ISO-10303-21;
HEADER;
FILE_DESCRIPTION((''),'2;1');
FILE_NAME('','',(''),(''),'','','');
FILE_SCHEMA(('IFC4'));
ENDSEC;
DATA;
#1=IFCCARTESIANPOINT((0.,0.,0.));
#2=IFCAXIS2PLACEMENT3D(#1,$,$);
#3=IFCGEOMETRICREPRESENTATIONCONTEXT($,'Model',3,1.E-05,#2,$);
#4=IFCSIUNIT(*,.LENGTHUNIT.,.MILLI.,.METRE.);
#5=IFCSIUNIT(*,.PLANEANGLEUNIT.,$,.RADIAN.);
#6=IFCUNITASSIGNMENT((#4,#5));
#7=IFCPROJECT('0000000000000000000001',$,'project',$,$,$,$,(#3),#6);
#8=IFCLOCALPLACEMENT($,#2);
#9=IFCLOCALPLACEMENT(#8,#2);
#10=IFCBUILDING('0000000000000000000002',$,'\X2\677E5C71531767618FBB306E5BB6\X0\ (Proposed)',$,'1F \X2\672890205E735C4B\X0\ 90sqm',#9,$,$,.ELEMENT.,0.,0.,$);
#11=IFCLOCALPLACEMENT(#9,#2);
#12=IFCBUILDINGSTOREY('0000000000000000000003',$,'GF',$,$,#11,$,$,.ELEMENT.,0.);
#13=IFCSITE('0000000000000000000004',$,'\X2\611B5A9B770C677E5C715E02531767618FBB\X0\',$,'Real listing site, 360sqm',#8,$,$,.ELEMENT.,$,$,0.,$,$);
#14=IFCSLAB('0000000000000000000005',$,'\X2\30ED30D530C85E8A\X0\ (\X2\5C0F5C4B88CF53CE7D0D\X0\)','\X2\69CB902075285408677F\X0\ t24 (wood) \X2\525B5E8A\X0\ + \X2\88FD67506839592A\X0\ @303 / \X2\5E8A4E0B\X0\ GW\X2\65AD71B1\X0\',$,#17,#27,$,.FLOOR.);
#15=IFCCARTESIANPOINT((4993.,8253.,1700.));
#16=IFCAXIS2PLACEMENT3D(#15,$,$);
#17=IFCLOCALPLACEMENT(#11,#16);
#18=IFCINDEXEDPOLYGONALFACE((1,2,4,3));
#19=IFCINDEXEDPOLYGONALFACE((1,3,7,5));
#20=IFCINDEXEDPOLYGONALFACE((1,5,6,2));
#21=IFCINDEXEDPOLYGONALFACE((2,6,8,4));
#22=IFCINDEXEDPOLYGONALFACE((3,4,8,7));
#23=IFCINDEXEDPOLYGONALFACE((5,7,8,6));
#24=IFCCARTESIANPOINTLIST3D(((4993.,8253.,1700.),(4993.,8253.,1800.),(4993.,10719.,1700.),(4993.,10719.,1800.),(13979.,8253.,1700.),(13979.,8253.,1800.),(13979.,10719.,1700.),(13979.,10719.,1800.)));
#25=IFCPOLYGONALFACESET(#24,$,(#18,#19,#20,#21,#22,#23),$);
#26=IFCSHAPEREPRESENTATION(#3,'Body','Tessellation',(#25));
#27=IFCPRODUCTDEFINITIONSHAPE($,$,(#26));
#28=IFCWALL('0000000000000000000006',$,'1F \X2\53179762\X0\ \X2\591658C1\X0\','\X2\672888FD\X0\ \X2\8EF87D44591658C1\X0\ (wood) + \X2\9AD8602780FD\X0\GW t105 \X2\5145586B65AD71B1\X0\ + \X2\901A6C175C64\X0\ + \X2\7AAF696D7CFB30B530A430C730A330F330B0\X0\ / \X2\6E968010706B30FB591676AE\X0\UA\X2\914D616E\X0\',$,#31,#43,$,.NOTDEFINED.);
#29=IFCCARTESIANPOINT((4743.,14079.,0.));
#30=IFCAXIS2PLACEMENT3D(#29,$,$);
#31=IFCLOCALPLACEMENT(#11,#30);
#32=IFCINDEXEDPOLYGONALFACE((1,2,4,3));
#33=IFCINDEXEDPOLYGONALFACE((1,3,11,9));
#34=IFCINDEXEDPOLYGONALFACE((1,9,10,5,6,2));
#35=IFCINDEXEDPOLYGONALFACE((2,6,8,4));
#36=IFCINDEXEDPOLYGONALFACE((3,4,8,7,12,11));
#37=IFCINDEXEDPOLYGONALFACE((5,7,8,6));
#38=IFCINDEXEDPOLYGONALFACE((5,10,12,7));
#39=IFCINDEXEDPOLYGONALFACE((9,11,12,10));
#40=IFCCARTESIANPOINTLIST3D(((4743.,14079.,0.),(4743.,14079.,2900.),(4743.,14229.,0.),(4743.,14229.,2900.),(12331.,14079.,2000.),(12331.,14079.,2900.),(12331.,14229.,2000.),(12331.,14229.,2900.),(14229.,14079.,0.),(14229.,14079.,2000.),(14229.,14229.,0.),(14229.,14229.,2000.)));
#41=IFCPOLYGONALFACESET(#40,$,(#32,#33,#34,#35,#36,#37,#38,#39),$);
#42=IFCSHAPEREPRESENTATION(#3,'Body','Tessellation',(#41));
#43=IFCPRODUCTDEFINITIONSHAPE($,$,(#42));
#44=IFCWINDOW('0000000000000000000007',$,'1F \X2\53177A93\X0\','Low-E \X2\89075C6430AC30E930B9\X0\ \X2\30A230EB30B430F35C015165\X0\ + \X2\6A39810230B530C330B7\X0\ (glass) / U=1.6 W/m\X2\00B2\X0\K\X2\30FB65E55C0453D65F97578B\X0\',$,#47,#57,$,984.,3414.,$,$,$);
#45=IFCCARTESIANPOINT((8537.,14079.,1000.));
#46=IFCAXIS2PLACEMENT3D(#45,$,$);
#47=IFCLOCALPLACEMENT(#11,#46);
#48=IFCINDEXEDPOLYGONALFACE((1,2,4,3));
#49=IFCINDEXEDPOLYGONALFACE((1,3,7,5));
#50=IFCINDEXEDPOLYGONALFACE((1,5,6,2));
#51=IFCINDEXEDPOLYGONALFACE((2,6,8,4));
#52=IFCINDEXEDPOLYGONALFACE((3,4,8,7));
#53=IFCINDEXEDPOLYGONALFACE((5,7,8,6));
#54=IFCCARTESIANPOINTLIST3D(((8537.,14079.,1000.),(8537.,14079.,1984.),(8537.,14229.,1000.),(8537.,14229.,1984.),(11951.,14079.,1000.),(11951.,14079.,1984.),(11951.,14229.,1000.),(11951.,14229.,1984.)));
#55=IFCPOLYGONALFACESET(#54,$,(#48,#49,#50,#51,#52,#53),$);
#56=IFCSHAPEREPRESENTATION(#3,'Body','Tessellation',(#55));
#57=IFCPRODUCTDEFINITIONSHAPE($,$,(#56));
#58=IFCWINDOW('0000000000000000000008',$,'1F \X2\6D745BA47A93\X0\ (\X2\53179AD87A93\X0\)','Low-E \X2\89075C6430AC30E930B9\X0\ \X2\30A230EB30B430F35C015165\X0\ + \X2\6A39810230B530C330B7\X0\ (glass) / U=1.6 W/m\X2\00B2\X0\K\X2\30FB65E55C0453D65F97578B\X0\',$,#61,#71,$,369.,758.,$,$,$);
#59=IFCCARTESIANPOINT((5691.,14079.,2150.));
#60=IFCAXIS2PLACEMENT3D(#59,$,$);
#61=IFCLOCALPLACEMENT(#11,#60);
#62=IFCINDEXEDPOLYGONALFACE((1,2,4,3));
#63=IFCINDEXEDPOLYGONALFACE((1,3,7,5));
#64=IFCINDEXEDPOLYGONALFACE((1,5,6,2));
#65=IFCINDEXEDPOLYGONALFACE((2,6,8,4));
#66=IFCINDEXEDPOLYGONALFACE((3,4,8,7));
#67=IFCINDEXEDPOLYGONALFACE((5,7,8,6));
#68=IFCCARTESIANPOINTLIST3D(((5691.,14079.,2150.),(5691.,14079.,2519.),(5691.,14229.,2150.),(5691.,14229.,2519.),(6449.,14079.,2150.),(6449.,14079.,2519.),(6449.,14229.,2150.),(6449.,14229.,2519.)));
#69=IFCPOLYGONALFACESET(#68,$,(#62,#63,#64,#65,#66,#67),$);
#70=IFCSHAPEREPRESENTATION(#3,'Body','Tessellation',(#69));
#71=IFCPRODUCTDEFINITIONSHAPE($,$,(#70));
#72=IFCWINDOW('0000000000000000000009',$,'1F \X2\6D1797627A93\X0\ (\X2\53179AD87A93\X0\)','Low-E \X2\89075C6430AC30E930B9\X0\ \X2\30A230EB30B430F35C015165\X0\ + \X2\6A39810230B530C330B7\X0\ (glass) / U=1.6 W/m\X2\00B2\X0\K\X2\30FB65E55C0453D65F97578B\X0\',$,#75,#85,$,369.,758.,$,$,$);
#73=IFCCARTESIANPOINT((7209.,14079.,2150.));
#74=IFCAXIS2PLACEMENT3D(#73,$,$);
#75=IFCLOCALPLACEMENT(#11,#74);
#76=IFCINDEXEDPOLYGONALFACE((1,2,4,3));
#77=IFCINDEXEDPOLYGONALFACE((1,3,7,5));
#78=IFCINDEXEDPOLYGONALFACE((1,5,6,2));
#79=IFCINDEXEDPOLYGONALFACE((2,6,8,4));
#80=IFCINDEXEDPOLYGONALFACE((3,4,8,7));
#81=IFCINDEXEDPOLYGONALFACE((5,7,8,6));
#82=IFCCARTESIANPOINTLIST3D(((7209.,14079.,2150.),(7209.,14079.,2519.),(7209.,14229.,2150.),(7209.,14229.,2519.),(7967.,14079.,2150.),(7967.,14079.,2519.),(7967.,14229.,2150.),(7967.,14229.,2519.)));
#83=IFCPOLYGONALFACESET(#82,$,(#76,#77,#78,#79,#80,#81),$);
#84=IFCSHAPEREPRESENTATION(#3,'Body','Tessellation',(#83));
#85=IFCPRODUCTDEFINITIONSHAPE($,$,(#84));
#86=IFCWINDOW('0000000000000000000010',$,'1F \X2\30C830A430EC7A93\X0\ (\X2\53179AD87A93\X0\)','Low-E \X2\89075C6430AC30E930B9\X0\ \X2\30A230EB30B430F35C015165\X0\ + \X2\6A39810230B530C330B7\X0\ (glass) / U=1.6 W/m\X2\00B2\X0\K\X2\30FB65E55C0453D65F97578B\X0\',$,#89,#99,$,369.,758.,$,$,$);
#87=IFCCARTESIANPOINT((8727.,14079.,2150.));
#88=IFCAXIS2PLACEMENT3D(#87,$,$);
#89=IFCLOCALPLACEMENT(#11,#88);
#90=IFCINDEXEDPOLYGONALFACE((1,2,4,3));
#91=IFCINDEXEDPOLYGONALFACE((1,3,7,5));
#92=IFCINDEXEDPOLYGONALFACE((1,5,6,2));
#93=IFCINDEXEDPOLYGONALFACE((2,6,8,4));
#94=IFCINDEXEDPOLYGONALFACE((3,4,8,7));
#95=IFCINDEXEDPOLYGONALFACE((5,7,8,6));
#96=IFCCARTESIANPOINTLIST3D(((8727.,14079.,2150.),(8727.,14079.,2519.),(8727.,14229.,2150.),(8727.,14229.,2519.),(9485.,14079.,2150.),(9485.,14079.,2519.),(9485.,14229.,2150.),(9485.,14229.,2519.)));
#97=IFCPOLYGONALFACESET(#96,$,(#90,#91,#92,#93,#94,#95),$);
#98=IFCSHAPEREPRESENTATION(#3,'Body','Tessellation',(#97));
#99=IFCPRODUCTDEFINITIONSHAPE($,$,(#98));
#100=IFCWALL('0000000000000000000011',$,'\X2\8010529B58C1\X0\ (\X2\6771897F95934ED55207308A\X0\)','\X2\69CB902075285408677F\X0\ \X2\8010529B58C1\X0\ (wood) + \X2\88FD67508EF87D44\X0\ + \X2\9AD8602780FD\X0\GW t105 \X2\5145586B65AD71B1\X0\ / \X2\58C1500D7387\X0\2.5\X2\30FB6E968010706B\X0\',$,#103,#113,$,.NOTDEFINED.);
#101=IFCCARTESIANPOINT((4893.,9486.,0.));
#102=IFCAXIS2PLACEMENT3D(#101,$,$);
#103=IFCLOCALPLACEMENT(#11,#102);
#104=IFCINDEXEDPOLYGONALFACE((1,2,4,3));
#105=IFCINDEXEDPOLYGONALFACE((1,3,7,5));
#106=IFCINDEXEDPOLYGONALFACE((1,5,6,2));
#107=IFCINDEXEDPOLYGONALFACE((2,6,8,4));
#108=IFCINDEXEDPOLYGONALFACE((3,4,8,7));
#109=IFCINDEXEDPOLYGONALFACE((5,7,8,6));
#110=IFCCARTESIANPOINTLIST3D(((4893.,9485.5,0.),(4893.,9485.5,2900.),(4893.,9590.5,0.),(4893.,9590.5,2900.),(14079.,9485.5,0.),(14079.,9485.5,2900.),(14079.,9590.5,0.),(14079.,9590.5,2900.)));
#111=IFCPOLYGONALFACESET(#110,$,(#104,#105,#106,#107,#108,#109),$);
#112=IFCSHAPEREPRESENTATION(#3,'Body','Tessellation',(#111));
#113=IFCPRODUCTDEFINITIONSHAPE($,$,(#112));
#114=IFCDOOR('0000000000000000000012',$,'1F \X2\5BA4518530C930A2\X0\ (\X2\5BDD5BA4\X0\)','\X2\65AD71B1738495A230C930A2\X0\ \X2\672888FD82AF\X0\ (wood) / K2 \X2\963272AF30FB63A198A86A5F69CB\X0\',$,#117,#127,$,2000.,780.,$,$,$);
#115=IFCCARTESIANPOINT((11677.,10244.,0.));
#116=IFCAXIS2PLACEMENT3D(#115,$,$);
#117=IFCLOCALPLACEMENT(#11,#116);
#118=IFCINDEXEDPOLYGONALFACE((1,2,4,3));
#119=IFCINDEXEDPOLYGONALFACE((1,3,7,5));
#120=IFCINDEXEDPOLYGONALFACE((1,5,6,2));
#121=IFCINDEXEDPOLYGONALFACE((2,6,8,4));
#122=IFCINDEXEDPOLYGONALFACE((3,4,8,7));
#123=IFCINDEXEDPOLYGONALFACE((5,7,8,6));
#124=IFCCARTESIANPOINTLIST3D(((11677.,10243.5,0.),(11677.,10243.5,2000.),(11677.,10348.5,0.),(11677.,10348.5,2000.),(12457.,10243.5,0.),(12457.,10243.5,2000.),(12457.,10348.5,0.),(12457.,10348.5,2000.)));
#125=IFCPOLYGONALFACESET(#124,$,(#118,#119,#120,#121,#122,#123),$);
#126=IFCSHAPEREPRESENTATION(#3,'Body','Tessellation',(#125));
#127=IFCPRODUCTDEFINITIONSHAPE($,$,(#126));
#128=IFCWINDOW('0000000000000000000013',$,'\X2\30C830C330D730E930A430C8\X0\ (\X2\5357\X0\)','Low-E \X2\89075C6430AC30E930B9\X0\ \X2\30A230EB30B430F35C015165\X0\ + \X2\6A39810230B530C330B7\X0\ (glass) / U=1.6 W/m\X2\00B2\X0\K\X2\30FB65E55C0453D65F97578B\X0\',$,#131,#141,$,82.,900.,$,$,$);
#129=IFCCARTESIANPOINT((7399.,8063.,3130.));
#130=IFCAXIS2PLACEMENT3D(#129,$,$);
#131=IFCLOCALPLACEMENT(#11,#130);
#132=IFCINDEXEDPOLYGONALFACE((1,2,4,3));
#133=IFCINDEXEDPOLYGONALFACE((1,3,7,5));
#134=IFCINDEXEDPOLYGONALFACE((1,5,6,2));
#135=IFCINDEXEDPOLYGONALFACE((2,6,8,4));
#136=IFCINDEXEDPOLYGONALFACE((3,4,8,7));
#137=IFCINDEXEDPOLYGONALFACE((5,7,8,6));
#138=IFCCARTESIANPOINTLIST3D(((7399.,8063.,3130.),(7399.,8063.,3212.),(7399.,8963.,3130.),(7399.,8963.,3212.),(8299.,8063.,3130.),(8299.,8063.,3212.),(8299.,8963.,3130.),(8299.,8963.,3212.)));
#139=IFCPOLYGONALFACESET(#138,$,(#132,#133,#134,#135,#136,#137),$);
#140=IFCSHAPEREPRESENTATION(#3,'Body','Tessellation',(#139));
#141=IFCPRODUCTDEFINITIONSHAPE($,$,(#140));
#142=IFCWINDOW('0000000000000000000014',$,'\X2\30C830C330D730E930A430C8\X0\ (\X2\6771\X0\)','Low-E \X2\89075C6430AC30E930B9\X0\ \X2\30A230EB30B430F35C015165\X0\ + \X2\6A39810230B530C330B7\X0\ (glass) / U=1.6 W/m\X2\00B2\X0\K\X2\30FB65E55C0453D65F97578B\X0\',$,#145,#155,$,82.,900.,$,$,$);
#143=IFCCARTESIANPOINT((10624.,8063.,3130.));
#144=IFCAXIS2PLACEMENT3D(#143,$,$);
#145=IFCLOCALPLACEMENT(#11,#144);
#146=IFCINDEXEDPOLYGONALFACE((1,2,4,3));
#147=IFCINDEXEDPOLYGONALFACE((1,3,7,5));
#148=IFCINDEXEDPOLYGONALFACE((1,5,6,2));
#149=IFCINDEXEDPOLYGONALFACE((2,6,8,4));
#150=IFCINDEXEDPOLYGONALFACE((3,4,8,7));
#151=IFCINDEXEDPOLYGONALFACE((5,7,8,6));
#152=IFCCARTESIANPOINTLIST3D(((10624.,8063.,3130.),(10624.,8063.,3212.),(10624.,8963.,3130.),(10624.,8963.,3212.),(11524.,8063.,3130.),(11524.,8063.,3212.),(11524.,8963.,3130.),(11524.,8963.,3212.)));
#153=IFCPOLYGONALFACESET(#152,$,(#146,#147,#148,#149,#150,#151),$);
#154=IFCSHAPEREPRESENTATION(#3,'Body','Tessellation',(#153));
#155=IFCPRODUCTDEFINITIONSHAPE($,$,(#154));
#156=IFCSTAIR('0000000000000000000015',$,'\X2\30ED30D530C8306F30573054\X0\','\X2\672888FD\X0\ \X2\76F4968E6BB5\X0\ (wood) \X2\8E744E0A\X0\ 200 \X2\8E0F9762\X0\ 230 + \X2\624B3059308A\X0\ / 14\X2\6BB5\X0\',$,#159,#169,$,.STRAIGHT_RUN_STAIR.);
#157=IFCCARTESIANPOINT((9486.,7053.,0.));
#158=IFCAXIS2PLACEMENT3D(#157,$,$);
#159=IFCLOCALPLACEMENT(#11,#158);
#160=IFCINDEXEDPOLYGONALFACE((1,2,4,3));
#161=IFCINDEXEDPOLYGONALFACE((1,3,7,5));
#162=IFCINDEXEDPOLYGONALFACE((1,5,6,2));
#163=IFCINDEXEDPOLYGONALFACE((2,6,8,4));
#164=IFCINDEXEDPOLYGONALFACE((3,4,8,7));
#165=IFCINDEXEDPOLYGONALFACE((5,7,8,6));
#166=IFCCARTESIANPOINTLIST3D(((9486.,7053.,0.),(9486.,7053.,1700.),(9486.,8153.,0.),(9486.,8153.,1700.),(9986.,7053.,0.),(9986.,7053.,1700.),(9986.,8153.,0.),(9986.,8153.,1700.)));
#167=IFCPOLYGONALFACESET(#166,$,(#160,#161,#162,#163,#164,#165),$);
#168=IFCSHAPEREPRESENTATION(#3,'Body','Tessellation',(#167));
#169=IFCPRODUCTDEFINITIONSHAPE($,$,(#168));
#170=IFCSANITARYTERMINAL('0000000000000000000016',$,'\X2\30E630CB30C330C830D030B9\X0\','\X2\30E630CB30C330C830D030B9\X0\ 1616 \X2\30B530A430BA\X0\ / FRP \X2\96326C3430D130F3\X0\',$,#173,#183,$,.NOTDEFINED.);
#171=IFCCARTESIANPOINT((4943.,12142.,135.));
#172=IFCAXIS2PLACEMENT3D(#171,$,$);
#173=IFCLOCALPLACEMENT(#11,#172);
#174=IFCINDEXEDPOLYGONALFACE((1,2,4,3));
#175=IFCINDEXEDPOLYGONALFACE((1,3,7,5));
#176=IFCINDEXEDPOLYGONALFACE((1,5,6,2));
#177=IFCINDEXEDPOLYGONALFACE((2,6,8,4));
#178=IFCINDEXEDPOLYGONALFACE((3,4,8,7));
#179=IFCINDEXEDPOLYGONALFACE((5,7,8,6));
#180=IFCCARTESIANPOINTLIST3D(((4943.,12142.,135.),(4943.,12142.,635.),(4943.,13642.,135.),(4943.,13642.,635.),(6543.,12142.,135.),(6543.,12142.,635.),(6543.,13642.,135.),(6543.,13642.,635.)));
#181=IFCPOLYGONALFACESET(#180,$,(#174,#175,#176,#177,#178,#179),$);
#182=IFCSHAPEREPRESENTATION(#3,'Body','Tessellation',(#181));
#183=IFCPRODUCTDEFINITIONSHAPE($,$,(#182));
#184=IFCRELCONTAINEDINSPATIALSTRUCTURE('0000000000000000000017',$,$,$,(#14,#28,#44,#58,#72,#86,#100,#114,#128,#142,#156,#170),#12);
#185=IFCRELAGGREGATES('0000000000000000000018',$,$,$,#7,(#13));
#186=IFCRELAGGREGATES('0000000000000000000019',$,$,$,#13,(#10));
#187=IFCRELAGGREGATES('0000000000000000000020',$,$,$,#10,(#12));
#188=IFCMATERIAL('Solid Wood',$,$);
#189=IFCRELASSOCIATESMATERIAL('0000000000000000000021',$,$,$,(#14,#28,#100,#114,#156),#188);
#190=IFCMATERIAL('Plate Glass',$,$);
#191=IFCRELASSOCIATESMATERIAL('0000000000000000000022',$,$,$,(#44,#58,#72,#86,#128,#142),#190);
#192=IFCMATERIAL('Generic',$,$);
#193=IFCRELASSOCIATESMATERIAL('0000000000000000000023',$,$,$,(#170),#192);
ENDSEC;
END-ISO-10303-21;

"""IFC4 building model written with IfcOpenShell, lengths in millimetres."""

from ifc_helpers import new_model, si_unit, frame, frame_2d, origin, place, context, project, spatial, rectangle, extrude, material, element, fill, save


model = new_model("IFC4")

# Units and contexts
model_context = context("Model", 3, precision=1e-05, world=origin())
ifc_project = project(units=[si_unit("LENGTHUNIT", "METRE", prefix="MILLI"), si_unit("PLANEANGLEUNIT", "RADIAN")], contexts=[model_context])

# Site, building, storey
site_placement = place(None, origin())
site = spatial("IfcSite", under=ifc_project, at=site_placement, Name="愛媛県松山市北条辻", ObjectType="Real listing site, 360sqm", CompositionType="ELEMENT", RefElevation=0.0)
building_placement = place(site_placement, origin())
building = spatial("IfcBuilding", under=site, at=building_placement, Name="松山北条辻の家 (Proposed)", ObjectType="1F 木造平屋 90sqm", CompositionType="ELEMENT", ElevationOfRefHeight=0.0, ElevationOfTerrain=0.0)
storey_placement = place(building_placement, origin())
storey = spatial("IfcBuildingStorey", under=building, at=storey_placement, Name="GF", CompositionType="ELEMENT", Elevation=0.0)

# Slab
ifc_material_1 = material(Name="Solid Wood")
slab_placement = place(storey_placement, frame((4993.0, 8253.0, 1700.0)))
element("IfcSlab", 1, at=slab_placement, inside=storey, material=ifc_material_1, Name="ロフト床 (小屋裏収納)", Description="構造用合板 t24 (wood) 剛床 + 製材根太 @303 / 床下 GW断熱", PredefinedType="FLOOR", context=model_context, shape_type="SweptSolid", body=[
    extrude(rectangle(XDim=8986.0, YDim=2466.0, at=frame_2d((4493.0, 1233.0))), frame((4993.0, 8253.0, 1700.0)), (0.0, 0.0, 1.0), 100.0),
])

# Wall, openings, windows
wall_1_placement = place(storey_placement, frame((4743.0, 14079.0, 0.0)))
wall_1 = element("IfcWall", 2, at=wall_1_placement, inside=storey, material=ifc_material_1, Name="1F 北面 外壁", Description="木製 軸組外壁 (wood) + 高性能GW t105 充填断熱 + 通気層 + 窯業系サイディング / 準耐火・外皮UA配慮", PredefinedType="NOTDEFINED", context=model_context, shape_type="SweptSolid", body=[
    extrude(rectangle(XDim=9486.0, YDim=150.0, at=frame_2d((4743.0, 75.0))), frame((4743.0, 14079.0, 0.0)), (0.0, 0.0, 1.0), 2900.0),
])
opening_1_placement = place(storey_placement, frame((8537.0, 14079.0, 1000.0)))
opening_1 = element("IfcOpeningElement", 3, at=opening_1_placement, cuts=wall_1, PredefinedType="NOTDEFINED", context=model_context, shape_type="SweptSolid", body=[
    extrude(rectangle(XDim=3414.0, YDim=150.0, at=frame_2d((1707.0, 75.0))), frame((8537.0, 14079.0, 1000.0)), (0.0, 0.0, 1.0), 984.0),
])
opening_2_placement = place(storey_placement, frame((5691.0, 14079.0, 2150.0)))
opening_2 = element("IfcOpeningElement", 4, at=opening_2_placement, cuts=wall_1, PredefinedType="NOTDEFINED", context=model_context, shape_type="SweptSolid", body=[
    extrude(rectangle(XDim=758.0, YDim=150.0, at=frame_2d((379.0, 75.0))), frame((5691.0, 14079.0, 2150.0)), (0.0, 0.0, 1.0), 369.0),
])
opening_3_placement = place(storey_placement, frame((7209.0, 14079.0, 2150.0)))
opening_3 = element("IfcOpeningElement", 5, at=opening_3_placement, cuts=wall_1, PredefinedType="NOTDEFINED", context=model_context, shape_type="SweptSolid", body=[
    extrude(rectangle(XDim=758.0, YDim=150.0, at=frame_2d((379.0, 75.0))), frame((7209.0, 14079.0, 2150.0)), (0.0, 0.0, 1.0), 369.0),
])
opening_4_placement = place(storey_placement, frame((8727.0, 14079.0, 2150.0)))
opening_4 = element("IfcOpeningElement", 6, at=opening_4_placement, cuts=wall_1, PredefinedType="NOTDEFINED", context=model_context, shape_type="SweptSolid", body=[
    extrude(rectangle(XDim=758.0, YDim=150.0, at=frame_2d((379.0, 75.0))), frame((8727.0, 14079.0, 2150.0)), (0.0, 0.0, 1.0), 369.0),
])
ifc_material_2 = material(Name="Plate Glass")
window_1_placement = place(storey_placement, frame((8537.0, 14079.0, 1000.0)))
window_1 = element("IfcWindow", 7, at=window_1_placement, inside=storey, material=ifc_material_2, Name="1F 北窓", Description="Low-E 複層ガラス アルゴン封入 + 樹脂サッシ (glass) / U=1.6 W/m²K・日射取得型", OverallHeight=984.0, OverallWidth=3414.0, context=model_context, shape_type="SweptSolid", body=[
    extrude(rectangle(XDim=3414.0, YDim=150.0, at=frame_2d((1707.0, 75.0))), frame((8537.0, 14079.0, 1000.0)), (0.0, 0.0, 1.0), 984.0),
])
fill(opening_1, window_1)
window_2_placement = place(storey_placement, frame((5691.0, 14079.0, 2150.0)))
window_2 = element("IfcWindow", 8, at=window_2_placement, inside=storey, material=ifc_material_2, Name="1F 浴室窓 (北高窓)", Description="Low-E 複層ガラス アルゴン封入 + 樹脂サッシ (glass) / U=1.6 W/m²K・日射取得型", OverallHeight=369.0, OverallWidth=758.0, context=model_context, shape_type="SweptSolid", body=[
    extrude(rectangle(XDim=758.0, YDim=150.0, at=frame_2d((379.0, 75.0))), frame((5691.0, 14079.0, 2150.0)), (0.0, 0.0, 1.0), 369.0),
])
fill(opening_2, window_2)
window_3_placement = place(storey_placement, frame((7209.0, 14079.0, 2150.0)))
window_3 = element("IfcWindow", 9, at=window_3_placement, inside=storey, material=ifc_material_2, Name="1F 洗面窓 (北高窓)", Description="Low-E 複層ガラス アルゴン封入 + 樹脂サッシ (glass) / U=1.6 W/m²K・日射取得型", OverallHeight=369.0, OverallWidth=758.0, context=model_context, shape_type="SweptSolid", body=[
    extrude(rectangle(XDim=758.0, YDim=150.0, at=frame_2d((379.0, 75.0))), frame((7209.0, 14079.0, 2150.0)), (0.0, 0.0, 1.0), 369.0),
])
fill(opening_3, window_3)
window_4_placement = place(storey_placement, frame((8727.0, 14079.0, 2150.0)))
window_4 = element("IfcWindow", 10, at=window_4_placement, inside=storey, material=ifc_material_2, Name="1F トイレ窓 (北高窓)", Description="Low-E 複層ガラス アルゴン封入 + 樹脂サッシ (glass) / U=1.6 W/m²K・日射取得型", OverallHeight=369.0, OverallWidth=758.0, context=model_context, shape_type="SweptSolid", body=[
    extrude(rectangle(XDim=758.0, YDim=150.0, at=frame_2d((379.0, 75.0))), frame((8727.0, 14079.0, 2150.0)), (0.0, 0.0, 1.0), 369.0),
])
fill(opening_4, window_4)

# Wall
wall_2_placement = place(storey_placement, frame((4893.0, 9486.0, 0.0)))
element("IfcWall", 11, at=wall_2_placement, inside=storey, material=ifc_material_1, Name="耐力壁 (東西間仕切り)", Description="構造用合板 耐力壁 (wood) + 製材軸組 + 高性能GW t105 充填断熱 / 壁倍率2.5・準耐火", PredefinedType="NOTDEFINED", context=model_context, shape_type="SweptSolid", body=[
    extrude(rectangle(XDim=9186.0, YDim=105.0, at=frame_2d((4593.0, 52.0))), frame((4893.0, 9486.0, 0.0)), (0.0, 0.0, 1.0), 2900.0),
])

# Door
door_1_placement = place(storey_placement, frame((11677.0, 10244.0, 0.0)))
element("IfcDoor", 12, at=door_1_placement, inside=storey, material=ifc_material_1, Name="1F 室内ドア (寝室)", Description="断熱玄関ドア 木製芯 (wood) / K2 防犯・採風機構", OverallHeight=2000.0, OverallWidth=780.0, context=model_context, shape_type="SweptSolid", body=[
    extrude(rectangle(XDim=780.0, YDim=105.0, at=frame_2d((390.0, 52.0))), frame((11677.0, 10244.0, 0.0)), (0.0, 0.0, 1.0), 2000.0),
])

# Windows
window_5_placement = place(storey_placement, frame((7399.0, 8063.0, 3130.0)))
element("IfcWindow", 13, at=window_5_placement, inside=storey, material=ifc_material_2, Name="トップライト (南)", Description="Low-E 複層ガラス アルゴン封入 + 樹脂サッシ (glass) / U=1.6 W/m²K・日射取得型", OverallHeight=82.0, OverallWidth=900.0, context=model_context, shape_type="SweptSolid", body=[
    extrude(rectangle(XDim=900.0, YDim=900.0, at=frame_2d((450.0, 450.0))), frame((7399.0, 8063.0, 3130.0)), (0.0, 0.0, 1.0), 82.0),
])
window_6_placement = place(storey_placement, frame((10624.0, 8063.0, 3130.0)))
element("IfcWindow", 14, at=window_6_placement, inside=storey, material=ifc_material_2, Name="トップライト (東)", Description="Low-E 複層ガラス アルゴン封入 + 樹脂サッシ (glass) / U=1.6 W/m²K・日射取得型", OverallHeight=82.0, OverallWidth=900.0, context=model_context, shape_type="SweptSolid", body=[
    extrude(rectangle(XDim=900.0, YDim=900.0, at=frame_2d((450.0, 450.0))), frame((10624.0, 8063.0, 3130.0)), (0.0, 0.0, 1.0), 82.0),
])

# Stair
stair_placement = place(storey_placement, frame((9486.0, 7053.0, 0.0)))
element("IfcStair", 15, at=stair_placement, inside=storey, material=ifc_material_1, Name="ロフトはしご", Description="木製 直階段 (wood) 蹴上 200 踏面 230 + 手すり / 14段", PredefinedType="STRAIGHT_RUN_STAIR", context=model_context, shape_type="SweptSolid", body=[
    extrude(rectangle(XDim=500.0, YDim=1100.0, at=frame_2d((250.0, 550.0))), frame((9486.0, 7053.0, 0.0)), (0.0, 0.0, 1.0), 1700.0),
])

# Sanitary terminal
ifc_material_3 = material(Name="Generic")
sanitary_terminal_1_placement = place(storey_placement, frame((4943.0, 12142.0, 135.0)))
element("IfcSanitaryTerminal", 16, at=sanitary_terminal_1_placement, inside=storey, material=ifc_material_3, Name="ユニットバス", Description="ユニットバス 1616 サイズ / FRP 防水パン", PredefinedType="NOTDEFINED", context=model_context, shape_type="SweptSolid", body=[
    extrude(rectangle(XDim=1600.0, YDim=1500.0, at=frame_2d((800.0, 750.0))), frame((4943.0, 12142.0, 135.0)), (0.0, 0.0, 1.0), 500.0),
])

save(model, "model.ifc")
